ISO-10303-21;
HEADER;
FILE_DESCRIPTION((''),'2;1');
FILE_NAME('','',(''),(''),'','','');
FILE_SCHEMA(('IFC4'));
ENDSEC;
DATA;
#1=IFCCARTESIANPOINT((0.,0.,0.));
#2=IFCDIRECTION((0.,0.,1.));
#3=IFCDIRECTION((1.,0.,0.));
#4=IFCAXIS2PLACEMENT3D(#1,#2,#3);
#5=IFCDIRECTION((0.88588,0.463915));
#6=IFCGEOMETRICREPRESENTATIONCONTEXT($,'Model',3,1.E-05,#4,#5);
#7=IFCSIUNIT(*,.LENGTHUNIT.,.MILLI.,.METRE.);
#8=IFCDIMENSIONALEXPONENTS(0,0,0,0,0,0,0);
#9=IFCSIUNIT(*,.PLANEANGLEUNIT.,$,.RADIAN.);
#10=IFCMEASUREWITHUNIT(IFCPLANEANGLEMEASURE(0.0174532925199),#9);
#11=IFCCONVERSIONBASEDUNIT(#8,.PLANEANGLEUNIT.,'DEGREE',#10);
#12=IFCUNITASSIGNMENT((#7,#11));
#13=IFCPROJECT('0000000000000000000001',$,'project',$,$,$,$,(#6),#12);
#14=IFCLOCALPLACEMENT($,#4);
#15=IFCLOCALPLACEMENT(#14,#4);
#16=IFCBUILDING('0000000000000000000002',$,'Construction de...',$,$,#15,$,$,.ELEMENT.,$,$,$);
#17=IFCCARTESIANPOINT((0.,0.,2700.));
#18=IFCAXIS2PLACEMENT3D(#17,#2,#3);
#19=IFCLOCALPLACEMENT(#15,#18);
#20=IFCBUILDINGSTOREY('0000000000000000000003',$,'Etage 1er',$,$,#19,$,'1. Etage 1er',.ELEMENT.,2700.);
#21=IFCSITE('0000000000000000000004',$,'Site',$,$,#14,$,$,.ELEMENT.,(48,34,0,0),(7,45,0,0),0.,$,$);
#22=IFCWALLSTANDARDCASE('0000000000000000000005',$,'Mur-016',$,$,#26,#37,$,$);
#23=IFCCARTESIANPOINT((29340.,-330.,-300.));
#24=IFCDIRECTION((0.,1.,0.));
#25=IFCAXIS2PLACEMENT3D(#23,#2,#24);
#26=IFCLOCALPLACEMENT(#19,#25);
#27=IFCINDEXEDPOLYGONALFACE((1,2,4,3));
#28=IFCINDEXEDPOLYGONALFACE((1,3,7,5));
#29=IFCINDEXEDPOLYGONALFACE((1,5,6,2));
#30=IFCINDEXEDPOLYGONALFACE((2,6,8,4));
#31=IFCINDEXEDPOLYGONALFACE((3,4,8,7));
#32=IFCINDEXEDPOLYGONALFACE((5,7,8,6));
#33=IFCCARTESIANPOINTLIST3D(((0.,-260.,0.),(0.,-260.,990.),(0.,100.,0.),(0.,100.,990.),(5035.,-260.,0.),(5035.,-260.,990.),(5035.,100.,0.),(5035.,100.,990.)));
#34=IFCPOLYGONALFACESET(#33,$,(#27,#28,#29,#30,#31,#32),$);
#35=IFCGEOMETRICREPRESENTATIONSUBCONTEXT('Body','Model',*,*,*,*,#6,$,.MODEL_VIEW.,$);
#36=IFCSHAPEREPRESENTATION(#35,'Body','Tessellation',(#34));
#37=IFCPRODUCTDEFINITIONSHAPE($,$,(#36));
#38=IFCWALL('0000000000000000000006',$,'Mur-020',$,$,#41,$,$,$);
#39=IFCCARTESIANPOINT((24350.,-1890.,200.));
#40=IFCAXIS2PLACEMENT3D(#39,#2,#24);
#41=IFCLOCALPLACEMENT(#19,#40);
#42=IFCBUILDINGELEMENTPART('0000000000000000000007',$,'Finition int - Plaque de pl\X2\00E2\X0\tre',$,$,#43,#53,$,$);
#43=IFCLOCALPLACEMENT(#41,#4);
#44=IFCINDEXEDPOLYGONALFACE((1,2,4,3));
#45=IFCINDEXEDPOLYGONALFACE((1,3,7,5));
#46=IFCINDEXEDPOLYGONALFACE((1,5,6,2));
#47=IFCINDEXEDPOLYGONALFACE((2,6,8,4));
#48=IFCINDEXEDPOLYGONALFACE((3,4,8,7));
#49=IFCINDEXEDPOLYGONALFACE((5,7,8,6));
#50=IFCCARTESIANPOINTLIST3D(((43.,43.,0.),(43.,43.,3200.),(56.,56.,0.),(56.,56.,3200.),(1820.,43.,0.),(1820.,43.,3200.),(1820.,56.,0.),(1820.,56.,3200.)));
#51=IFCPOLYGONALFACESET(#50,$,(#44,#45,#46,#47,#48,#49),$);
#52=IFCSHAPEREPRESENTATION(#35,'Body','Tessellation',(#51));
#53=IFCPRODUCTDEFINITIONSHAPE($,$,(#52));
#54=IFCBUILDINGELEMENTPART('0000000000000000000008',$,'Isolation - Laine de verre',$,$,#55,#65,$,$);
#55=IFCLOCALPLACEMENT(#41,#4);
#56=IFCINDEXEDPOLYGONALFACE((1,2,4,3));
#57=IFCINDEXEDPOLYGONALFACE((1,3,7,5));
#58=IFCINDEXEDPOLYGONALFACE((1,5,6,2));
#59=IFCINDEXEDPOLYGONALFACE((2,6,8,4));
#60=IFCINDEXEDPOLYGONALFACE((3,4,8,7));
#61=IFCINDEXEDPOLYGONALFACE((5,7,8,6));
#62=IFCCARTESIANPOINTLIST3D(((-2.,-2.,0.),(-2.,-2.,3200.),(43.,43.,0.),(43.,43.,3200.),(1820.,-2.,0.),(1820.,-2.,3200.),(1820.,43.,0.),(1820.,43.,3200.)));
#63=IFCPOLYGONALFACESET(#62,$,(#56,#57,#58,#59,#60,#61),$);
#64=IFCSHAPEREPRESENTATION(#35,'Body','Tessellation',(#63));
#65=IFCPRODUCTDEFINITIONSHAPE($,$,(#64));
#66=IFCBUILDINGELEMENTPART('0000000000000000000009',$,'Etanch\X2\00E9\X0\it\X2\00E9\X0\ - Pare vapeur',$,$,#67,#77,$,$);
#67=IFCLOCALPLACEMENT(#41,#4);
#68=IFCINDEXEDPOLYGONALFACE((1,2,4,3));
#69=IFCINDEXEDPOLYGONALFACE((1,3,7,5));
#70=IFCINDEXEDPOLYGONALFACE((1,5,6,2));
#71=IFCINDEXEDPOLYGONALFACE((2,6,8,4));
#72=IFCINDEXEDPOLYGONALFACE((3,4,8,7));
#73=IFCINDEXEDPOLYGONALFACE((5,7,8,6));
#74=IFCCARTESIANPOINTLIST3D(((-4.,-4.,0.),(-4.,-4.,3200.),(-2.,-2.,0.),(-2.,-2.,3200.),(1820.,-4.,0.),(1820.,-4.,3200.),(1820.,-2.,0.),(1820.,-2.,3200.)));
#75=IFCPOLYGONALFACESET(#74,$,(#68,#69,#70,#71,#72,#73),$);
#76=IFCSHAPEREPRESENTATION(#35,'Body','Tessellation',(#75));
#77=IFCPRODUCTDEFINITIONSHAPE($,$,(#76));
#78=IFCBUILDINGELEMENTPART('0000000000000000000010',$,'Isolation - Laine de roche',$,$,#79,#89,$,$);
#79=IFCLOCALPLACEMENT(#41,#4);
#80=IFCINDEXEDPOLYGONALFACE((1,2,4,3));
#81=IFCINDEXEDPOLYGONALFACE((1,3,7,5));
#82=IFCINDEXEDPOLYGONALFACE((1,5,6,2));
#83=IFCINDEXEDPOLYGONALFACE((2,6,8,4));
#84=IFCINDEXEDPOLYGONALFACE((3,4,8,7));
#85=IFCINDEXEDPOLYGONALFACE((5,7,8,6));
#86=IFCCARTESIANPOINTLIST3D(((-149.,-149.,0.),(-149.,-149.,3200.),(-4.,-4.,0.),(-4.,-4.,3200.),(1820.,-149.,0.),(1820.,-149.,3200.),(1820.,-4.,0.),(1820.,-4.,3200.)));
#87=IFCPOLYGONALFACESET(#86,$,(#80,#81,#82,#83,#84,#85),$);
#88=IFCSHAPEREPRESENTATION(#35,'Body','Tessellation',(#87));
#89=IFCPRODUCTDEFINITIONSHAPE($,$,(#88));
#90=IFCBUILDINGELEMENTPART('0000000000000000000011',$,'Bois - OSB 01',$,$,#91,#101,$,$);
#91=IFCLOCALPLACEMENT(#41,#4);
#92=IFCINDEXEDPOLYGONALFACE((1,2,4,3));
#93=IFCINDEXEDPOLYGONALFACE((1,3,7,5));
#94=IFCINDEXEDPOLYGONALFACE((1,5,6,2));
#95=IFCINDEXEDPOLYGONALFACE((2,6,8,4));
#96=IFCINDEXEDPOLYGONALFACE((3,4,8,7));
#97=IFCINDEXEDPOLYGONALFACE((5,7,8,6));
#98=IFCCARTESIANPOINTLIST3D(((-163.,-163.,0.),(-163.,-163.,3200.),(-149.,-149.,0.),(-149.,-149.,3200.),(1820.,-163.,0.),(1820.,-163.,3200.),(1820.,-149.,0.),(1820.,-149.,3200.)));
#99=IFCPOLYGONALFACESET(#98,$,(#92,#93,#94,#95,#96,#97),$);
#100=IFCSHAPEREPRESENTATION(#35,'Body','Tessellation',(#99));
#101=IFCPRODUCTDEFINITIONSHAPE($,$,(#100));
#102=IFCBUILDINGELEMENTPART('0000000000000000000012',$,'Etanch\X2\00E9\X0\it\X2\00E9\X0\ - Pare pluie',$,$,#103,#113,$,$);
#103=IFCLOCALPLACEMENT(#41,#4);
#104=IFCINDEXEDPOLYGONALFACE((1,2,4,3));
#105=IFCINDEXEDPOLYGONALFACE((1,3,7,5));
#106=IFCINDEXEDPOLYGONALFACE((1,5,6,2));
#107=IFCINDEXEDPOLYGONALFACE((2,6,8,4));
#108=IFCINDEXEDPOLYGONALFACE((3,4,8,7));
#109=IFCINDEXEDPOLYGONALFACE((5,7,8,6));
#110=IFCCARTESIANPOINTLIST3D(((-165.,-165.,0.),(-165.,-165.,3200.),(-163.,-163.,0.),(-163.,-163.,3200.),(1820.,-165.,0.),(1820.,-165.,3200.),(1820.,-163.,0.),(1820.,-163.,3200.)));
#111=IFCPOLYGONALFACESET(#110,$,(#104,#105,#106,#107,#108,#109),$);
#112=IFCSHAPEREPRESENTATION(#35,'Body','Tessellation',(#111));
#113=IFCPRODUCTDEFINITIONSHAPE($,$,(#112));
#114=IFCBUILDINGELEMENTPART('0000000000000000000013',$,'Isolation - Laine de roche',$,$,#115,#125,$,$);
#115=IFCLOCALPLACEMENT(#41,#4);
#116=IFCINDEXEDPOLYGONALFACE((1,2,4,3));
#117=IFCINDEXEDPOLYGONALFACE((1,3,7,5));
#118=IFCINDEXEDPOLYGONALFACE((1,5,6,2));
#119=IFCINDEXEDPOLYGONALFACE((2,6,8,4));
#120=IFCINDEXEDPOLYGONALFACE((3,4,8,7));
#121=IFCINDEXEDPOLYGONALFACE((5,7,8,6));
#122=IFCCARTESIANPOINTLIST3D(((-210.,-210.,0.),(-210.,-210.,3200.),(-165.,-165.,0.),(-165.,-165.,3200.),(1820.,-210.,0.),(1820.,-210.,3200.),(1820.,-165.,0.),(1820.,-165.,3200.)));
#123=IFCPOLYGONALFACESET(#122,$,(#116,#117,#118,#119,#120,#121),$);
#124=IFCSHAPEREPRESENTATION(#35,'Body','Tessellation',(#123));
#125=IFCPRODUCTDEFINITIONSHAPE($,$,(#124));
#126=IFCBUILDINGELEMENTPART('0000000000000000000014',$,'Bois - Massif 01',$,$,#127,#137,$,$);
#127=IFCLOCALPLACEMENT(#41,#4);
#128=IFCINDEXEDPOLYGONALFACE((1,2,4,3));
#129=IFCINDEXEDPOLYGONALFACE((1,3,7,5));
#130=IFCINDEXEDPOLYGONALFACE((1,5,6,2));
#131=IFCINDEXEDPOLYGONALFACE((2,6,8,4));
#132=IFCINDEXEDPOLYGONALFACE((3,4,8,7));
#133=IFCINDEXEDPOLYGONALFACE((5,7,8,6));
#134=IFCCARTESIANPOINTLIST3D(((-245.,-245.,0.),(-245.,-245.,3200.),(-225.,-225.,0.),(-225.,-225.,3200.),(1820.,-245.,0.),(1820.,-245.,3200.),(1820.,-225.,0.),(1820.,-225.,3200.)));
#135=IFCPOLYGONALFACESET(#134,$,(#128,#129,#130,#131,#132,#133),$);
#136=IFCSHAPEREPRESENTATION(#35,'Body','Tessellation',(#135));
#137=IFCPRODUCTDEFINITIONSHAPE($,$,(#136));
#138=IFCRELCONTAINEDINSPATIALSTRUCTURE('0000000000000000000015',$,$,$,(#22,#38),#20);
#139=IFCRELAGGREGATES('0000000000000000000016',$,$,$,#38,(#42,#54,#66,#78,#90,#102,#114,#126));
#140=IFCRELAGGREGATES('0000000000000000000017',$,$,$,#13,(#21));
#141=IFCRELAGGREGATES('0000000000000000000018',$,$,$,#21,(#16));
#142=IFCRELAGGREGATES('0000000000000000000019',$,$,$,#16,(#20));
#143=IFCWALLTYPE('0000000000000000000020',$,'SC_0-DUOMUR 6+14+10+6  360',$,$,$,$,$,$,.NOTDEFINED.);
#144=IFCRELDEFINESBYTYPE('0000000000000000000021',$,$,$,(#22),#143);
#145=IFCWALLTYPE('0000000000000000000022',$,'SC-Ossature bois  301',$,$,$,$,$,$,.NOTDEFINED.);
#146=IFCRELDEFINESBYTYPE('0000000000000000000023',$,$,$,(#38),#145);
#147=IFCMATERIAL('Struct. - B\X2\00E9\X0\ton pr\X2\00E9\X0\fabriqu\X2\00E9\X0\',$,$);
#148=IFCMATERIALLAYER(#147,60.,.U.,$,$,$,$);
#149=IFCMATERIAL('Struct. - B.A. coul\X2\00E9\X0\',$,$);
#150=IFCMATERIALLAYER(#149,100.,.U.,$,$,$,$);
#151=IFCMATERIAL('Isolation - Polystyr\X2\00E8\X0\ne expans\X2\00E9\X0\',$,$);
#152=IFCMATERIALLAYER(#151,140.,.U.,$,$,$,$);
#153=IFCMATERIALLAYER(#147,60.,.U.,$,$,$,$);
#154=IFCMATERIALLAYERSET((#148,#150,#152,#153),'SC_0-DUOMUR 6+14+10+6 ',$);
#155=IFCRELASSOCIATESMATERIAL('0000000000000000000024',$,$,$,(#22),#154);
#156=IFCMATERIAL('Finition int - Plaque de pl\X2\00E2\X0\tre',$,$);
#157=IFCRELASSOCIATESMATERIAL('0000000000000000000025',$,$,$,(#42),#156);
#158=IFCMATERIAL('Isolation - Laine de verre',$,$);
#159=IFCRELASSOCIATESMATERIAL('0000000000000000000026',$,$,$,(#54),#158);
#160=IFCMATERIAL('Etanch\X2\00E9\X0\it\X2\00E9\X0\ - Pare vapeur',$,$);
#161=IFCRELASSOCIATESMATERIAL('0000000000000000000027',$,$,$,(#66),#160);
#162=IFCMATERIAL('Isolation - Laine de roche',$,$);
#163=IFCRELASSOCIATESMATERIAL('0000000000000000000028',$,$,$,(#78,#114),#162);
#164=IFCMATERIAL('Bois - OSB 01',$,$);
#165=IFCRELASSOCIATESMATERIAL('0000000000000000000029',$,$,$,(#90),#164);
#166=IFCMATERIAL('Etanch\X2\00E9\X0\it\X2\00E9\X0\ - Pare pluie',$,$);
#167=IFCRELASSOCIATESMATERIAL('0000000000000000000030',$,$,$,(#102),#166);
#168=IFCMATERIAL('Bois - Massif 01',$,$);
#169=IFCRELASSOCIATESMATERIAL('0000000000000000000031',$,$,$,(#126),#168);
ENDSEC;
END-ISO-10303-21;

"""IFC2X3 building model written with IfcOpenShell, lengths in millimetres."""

from ifc_helpers import new_model, entity, si_unit, converted_unit, direction, frame, origin_with_axes, place, context, subcontext, project, spatial, polyline, outline, extrude, material, layer, layer_set, layer_usage, type_object, element, aggregate, save


model = new_model("IFC2X3")

# Units and contexts
model_context = context("Model", 3, precision=1e-05, world=origin_with_axes(), true_north=direction((0.88588, 0.463915)))
body_context = subcontext(model_context, "Body", "Model", "MODEL_VIEW")
ifc_project = project(units=[si_unit("LENGTHUNIT", "METRE", prefix="MILLI"), converted_unit("PLANEANGLEUNIT", "DEGREE", entity("IfcPlaneAngleMeasure", 0.0174532925199), si_unit("PLANEANGLEUNIT", "RADIAN"), dimensions=[0, 0, 0, 0, 0, 0, 0])], contexts=[model_context])

# Site, building, storey
site_placement = place(None, origin_with_axes())
site = spatial("IfcSite", under=ifc_project, at=site_placement, Name="Site", CompositionType="ELEMENT", RefLatitude=(48, 34, 0, 0), RefLongitude=(7, 45, 0, 0), RefElevation=0.0)
building_placement = place(site_placement, origin_with_axes())
building = spatial("IfcBuilding", under=site, at=building_placement, Name="Construction de...", CompositionType="ELEMENT")
storey_placement = place(building_placement, frame((0.0, 0.0, 2700.0), z_axis=(0.0, 0.0, 1.0), x_axis=(1.0, 0.0, 0.0)))
storey = spatial("IfcBuildingStorey", under=building, at=storey_placement, Name="Etage 1er", LongName="1. Etage 1er", CompositionType="ELEMENT", Elevation=2700.0)

# Wall
ifc_material_1 = material(Name="Struct. - Béton préfabriqué")
ifc_layer_1 = layer(ifc_material_1, 60.0, ventilated="UNKNOWN")
ifc_material_2 = material(Name="Struct. - B.A. coulé")
ifc_layer_2 = layer(ifc_material_2, 100.0, ventilated="UNKNOWN")
ifc_material_3 = material(Name="Isolation - Polystyrène expansé")
ifc_layer_3 = layer(ifc_material_3, 140.0, ventilated="UNKNOWN")
ifc_layer_4 = layer(ifc_material_1, 60.0, ventilated="UNKNOWN")
ifc_layer_set_1 = layer_set([ifc_layer_1, ifc_layer_2, ifc_layer_3, ifc_layer_4], Name="SC_0-DUOMUR 6+14+10+6 ")
ifc_layer_usage_1 = layer_usage(ifc_layer_set_1, "AXIS2", "NEGATIVE", 100.0)
wall_type_1 = type_object("IfcWallType", Name="SC_0-DUOMUR 6+14+10+6  360", PredefinedType="NOTDEFINED")
wall_1_placement = place(storey_placement, frame((29340.0, -330.0, -300.0), z_axis=(0.0, 0.0, 1.0), x_axis=(0.0, 1.0, 0.0)))
element("IfcWallStandardCase", 1, at=wall_1_placement, inside=storey, type_object=wall_type_1, material=ifc_layer_usage_1, Name="Mur-016", context=body_context, shape_type="SweptSolid", body=[
    extrude(outline(polyline([(0.0, -260.0), (5035.0, -260.0), (5035.0, 100.0), (0.0, 100.0), (0.0, -260.0)])), origin_with_axes(), (0.0, 0.0, 1.0), 990.0),
])

# Wall, building element parts
wall_type_2 = type_object("IfcWallType", Name="SC-Ossature bois  301", PredefinedType="NOTDEFINED")
wall_2_placement = place(storey_placement, frame((24350.0, -1890.0, 200.0), z_axis=(0.0, 0.0, 1.0), x_axis=(0.0, 1.0, 0.0)))
wall_2 = element("IfcWall", 2, at=wall_2_placement, inside=storey, type_object=wall_type_2, Name="Mur-020")
ifc_material_4 = material(Name="Finition int - Plaque de plâtre")
building_element_part_1_placement = place(wall_2_placement, origin_with_axes())
building_element_part_1 = element("IfcBuildingElementPart", 3, at=building_element_part_1_placement, material=ifc_material_4, Name="Finition int - Plaque de plâtre", context=body_context, shape_type="SweptSolid", body=[
    extrude(outline(polyline([(43.0, 43.0), (1820.0, 43.0), (1820.0, 56.0), (56.0, 56.0), (43.0, 43.0)])), origin_with_axes(), (0.0, 0.0, 1.0), 3200.0),
])
ifc_material_5 = material(Name="Isolation - Laine de verre")
building_element_part_2_placement = place(wall_2_placement, origin_with_axes())
building_element_part_2 = element("IfcBuildingElementPart", 4, at=building_element_part_2_placement, material=ifc_material_5, Name="Isolation - Laine de verre", context=body_context, shape_type="SweptSolid", body=[
    extrude(outline(polyline([(-2.0, -2.0), (1820.0, -2.0), (1820.0, 43.0), (43.0, 43.0), (-2.0, -2.0)])), origin_with_axes(), (0.0, 0.0, 1.0), 3200.0),
])
ifc_material_6 = material(Name="Etanchéité - Pare vapeur")
building_element_part_3_placement = place(wall_2_placement, origin_with_axes())
building_element_part_3 = element("IfcBuildingElementPart", 5, at=building_element_part_3_placement, material=ifc_material_6, Name="Etanchéité - Pare vapeur", context=body_context, shape_type="SweptSolid", body=[
    extrude(outline(polyline([(-4.0, -4.0), (1820.0, -4.0), (1820.0, -2.0), (-2.0, -2.0), (-4.0, -4.0)])), origin_with_axes(), (0.0, 0.0, 1.0), 3200.0),
])
ifc_material_7 = material(Name="Isolation - Laine de roche")
building_element_part_4_placement = place(wall_2_placement, origin_with_axes())
building_element_part_4 = element("IfcBuildingElementPart", 6, at=building_element_part_4_placement, material=ifc_material_7, Name="Isolation - Laine de roche", context=body_context, shape_type="SweptSolid", body=[
    extrude(outline(polyline([(-149.0, -149.0), (1820.0, -149.0), (1820.0, -4.0), (-4.0, -4.0), (-149.0, -149.0)])), origin_with_axes(), (0.0, 0.0, 1.0), 3200.0),
])
ifc_material_8 = material(Name="Bois - OSB 01")
building_element_part_5_placement = place(wall_2_placement, origin_with_axes())
building_element_part_5 = element("IfcBuildingElementPart", 7, at=building_element_part_5_placement, material=ifc_material_8, Name="Bois - OSB 01", context=body_context, shape_type="SweptSolid", body=[
    extrude(outline(polyline([(-163.0, -163.0), (1820.0, -163.0), (1820.0, -149.0), (-149.0, -149.0), (-163.0, -163.0)])), origin_with_axes(), (0.0, 0.0, 1.0), 3200.0),
])
ifc_material_9 = material(Name="Etanchéité - Pare pluie")
building_element_part_6_placement = place(wall_2_placement, origin_with_axes())
building_element_part_6 = element("IfcBuildingElementPart", 8, at=building_element_part_6_placement, material=ifc_material_9, Name="Etanchéité - Pare pluie", context=body_context, shape_type="SweptSolid", body=[
    extrude(outline(polyline([(-165.0, -165.0), (1820.0, -165.0), (1820.0, -163.0), (-163.0, -163.0), (-165.0, -165.0)])), origin_with_axes(), (0.0, 0.0, 1.0), 3200.0),
])
building_element_part_7_placement = place(wall_2_placement, origin_with_axes())
building_element_part_7 = element("IfcBuildingElementPart", 9, at=building_element_part_7_placement, material=ifc_material_7, Name="Isolation - Laine de roche", context=body_context, shape_type="SweptSolid", body=[
    extrude(outline(polyline([(-210.0, -210.0), (1820.0, -210.0), (1820.0, -165.0), (-165.0, -165.0), (-210.0, -210.0)])), origin_with_axes(), (0.0, 0.0, 1.0), 3200.0),
])
ifc_material_10 = material(Name="Bois - Massif 01")
building_element_part_8_placement = place(wall_2_placement, origin_with_axes())
building_element_part_8 = element("IfcBuildingElementPart", 10, at=building_element_part_8_placement, material=ifc_material_10, Name="Bois - Massif 01", context=body_context, shape_type="SweptSolid", body=[
    extrude(outline(polyline([(-245.0, -245.0), (1820.0, -245.0), (1820.0, -225.0), (-225.0, -225.0), (-245.0, -245.0)])), origin_with_axes(), (0.0, 0.0, 1.0), 3200.0),
])
aggregate(wall_2, [building_element_part_1, building_element_part_2, building_element_part_3, building_element_part_4, building_element_part_5, building_element_part_6, building_element_part_7, building_element_part_8])

save(model, "model.ifc")
